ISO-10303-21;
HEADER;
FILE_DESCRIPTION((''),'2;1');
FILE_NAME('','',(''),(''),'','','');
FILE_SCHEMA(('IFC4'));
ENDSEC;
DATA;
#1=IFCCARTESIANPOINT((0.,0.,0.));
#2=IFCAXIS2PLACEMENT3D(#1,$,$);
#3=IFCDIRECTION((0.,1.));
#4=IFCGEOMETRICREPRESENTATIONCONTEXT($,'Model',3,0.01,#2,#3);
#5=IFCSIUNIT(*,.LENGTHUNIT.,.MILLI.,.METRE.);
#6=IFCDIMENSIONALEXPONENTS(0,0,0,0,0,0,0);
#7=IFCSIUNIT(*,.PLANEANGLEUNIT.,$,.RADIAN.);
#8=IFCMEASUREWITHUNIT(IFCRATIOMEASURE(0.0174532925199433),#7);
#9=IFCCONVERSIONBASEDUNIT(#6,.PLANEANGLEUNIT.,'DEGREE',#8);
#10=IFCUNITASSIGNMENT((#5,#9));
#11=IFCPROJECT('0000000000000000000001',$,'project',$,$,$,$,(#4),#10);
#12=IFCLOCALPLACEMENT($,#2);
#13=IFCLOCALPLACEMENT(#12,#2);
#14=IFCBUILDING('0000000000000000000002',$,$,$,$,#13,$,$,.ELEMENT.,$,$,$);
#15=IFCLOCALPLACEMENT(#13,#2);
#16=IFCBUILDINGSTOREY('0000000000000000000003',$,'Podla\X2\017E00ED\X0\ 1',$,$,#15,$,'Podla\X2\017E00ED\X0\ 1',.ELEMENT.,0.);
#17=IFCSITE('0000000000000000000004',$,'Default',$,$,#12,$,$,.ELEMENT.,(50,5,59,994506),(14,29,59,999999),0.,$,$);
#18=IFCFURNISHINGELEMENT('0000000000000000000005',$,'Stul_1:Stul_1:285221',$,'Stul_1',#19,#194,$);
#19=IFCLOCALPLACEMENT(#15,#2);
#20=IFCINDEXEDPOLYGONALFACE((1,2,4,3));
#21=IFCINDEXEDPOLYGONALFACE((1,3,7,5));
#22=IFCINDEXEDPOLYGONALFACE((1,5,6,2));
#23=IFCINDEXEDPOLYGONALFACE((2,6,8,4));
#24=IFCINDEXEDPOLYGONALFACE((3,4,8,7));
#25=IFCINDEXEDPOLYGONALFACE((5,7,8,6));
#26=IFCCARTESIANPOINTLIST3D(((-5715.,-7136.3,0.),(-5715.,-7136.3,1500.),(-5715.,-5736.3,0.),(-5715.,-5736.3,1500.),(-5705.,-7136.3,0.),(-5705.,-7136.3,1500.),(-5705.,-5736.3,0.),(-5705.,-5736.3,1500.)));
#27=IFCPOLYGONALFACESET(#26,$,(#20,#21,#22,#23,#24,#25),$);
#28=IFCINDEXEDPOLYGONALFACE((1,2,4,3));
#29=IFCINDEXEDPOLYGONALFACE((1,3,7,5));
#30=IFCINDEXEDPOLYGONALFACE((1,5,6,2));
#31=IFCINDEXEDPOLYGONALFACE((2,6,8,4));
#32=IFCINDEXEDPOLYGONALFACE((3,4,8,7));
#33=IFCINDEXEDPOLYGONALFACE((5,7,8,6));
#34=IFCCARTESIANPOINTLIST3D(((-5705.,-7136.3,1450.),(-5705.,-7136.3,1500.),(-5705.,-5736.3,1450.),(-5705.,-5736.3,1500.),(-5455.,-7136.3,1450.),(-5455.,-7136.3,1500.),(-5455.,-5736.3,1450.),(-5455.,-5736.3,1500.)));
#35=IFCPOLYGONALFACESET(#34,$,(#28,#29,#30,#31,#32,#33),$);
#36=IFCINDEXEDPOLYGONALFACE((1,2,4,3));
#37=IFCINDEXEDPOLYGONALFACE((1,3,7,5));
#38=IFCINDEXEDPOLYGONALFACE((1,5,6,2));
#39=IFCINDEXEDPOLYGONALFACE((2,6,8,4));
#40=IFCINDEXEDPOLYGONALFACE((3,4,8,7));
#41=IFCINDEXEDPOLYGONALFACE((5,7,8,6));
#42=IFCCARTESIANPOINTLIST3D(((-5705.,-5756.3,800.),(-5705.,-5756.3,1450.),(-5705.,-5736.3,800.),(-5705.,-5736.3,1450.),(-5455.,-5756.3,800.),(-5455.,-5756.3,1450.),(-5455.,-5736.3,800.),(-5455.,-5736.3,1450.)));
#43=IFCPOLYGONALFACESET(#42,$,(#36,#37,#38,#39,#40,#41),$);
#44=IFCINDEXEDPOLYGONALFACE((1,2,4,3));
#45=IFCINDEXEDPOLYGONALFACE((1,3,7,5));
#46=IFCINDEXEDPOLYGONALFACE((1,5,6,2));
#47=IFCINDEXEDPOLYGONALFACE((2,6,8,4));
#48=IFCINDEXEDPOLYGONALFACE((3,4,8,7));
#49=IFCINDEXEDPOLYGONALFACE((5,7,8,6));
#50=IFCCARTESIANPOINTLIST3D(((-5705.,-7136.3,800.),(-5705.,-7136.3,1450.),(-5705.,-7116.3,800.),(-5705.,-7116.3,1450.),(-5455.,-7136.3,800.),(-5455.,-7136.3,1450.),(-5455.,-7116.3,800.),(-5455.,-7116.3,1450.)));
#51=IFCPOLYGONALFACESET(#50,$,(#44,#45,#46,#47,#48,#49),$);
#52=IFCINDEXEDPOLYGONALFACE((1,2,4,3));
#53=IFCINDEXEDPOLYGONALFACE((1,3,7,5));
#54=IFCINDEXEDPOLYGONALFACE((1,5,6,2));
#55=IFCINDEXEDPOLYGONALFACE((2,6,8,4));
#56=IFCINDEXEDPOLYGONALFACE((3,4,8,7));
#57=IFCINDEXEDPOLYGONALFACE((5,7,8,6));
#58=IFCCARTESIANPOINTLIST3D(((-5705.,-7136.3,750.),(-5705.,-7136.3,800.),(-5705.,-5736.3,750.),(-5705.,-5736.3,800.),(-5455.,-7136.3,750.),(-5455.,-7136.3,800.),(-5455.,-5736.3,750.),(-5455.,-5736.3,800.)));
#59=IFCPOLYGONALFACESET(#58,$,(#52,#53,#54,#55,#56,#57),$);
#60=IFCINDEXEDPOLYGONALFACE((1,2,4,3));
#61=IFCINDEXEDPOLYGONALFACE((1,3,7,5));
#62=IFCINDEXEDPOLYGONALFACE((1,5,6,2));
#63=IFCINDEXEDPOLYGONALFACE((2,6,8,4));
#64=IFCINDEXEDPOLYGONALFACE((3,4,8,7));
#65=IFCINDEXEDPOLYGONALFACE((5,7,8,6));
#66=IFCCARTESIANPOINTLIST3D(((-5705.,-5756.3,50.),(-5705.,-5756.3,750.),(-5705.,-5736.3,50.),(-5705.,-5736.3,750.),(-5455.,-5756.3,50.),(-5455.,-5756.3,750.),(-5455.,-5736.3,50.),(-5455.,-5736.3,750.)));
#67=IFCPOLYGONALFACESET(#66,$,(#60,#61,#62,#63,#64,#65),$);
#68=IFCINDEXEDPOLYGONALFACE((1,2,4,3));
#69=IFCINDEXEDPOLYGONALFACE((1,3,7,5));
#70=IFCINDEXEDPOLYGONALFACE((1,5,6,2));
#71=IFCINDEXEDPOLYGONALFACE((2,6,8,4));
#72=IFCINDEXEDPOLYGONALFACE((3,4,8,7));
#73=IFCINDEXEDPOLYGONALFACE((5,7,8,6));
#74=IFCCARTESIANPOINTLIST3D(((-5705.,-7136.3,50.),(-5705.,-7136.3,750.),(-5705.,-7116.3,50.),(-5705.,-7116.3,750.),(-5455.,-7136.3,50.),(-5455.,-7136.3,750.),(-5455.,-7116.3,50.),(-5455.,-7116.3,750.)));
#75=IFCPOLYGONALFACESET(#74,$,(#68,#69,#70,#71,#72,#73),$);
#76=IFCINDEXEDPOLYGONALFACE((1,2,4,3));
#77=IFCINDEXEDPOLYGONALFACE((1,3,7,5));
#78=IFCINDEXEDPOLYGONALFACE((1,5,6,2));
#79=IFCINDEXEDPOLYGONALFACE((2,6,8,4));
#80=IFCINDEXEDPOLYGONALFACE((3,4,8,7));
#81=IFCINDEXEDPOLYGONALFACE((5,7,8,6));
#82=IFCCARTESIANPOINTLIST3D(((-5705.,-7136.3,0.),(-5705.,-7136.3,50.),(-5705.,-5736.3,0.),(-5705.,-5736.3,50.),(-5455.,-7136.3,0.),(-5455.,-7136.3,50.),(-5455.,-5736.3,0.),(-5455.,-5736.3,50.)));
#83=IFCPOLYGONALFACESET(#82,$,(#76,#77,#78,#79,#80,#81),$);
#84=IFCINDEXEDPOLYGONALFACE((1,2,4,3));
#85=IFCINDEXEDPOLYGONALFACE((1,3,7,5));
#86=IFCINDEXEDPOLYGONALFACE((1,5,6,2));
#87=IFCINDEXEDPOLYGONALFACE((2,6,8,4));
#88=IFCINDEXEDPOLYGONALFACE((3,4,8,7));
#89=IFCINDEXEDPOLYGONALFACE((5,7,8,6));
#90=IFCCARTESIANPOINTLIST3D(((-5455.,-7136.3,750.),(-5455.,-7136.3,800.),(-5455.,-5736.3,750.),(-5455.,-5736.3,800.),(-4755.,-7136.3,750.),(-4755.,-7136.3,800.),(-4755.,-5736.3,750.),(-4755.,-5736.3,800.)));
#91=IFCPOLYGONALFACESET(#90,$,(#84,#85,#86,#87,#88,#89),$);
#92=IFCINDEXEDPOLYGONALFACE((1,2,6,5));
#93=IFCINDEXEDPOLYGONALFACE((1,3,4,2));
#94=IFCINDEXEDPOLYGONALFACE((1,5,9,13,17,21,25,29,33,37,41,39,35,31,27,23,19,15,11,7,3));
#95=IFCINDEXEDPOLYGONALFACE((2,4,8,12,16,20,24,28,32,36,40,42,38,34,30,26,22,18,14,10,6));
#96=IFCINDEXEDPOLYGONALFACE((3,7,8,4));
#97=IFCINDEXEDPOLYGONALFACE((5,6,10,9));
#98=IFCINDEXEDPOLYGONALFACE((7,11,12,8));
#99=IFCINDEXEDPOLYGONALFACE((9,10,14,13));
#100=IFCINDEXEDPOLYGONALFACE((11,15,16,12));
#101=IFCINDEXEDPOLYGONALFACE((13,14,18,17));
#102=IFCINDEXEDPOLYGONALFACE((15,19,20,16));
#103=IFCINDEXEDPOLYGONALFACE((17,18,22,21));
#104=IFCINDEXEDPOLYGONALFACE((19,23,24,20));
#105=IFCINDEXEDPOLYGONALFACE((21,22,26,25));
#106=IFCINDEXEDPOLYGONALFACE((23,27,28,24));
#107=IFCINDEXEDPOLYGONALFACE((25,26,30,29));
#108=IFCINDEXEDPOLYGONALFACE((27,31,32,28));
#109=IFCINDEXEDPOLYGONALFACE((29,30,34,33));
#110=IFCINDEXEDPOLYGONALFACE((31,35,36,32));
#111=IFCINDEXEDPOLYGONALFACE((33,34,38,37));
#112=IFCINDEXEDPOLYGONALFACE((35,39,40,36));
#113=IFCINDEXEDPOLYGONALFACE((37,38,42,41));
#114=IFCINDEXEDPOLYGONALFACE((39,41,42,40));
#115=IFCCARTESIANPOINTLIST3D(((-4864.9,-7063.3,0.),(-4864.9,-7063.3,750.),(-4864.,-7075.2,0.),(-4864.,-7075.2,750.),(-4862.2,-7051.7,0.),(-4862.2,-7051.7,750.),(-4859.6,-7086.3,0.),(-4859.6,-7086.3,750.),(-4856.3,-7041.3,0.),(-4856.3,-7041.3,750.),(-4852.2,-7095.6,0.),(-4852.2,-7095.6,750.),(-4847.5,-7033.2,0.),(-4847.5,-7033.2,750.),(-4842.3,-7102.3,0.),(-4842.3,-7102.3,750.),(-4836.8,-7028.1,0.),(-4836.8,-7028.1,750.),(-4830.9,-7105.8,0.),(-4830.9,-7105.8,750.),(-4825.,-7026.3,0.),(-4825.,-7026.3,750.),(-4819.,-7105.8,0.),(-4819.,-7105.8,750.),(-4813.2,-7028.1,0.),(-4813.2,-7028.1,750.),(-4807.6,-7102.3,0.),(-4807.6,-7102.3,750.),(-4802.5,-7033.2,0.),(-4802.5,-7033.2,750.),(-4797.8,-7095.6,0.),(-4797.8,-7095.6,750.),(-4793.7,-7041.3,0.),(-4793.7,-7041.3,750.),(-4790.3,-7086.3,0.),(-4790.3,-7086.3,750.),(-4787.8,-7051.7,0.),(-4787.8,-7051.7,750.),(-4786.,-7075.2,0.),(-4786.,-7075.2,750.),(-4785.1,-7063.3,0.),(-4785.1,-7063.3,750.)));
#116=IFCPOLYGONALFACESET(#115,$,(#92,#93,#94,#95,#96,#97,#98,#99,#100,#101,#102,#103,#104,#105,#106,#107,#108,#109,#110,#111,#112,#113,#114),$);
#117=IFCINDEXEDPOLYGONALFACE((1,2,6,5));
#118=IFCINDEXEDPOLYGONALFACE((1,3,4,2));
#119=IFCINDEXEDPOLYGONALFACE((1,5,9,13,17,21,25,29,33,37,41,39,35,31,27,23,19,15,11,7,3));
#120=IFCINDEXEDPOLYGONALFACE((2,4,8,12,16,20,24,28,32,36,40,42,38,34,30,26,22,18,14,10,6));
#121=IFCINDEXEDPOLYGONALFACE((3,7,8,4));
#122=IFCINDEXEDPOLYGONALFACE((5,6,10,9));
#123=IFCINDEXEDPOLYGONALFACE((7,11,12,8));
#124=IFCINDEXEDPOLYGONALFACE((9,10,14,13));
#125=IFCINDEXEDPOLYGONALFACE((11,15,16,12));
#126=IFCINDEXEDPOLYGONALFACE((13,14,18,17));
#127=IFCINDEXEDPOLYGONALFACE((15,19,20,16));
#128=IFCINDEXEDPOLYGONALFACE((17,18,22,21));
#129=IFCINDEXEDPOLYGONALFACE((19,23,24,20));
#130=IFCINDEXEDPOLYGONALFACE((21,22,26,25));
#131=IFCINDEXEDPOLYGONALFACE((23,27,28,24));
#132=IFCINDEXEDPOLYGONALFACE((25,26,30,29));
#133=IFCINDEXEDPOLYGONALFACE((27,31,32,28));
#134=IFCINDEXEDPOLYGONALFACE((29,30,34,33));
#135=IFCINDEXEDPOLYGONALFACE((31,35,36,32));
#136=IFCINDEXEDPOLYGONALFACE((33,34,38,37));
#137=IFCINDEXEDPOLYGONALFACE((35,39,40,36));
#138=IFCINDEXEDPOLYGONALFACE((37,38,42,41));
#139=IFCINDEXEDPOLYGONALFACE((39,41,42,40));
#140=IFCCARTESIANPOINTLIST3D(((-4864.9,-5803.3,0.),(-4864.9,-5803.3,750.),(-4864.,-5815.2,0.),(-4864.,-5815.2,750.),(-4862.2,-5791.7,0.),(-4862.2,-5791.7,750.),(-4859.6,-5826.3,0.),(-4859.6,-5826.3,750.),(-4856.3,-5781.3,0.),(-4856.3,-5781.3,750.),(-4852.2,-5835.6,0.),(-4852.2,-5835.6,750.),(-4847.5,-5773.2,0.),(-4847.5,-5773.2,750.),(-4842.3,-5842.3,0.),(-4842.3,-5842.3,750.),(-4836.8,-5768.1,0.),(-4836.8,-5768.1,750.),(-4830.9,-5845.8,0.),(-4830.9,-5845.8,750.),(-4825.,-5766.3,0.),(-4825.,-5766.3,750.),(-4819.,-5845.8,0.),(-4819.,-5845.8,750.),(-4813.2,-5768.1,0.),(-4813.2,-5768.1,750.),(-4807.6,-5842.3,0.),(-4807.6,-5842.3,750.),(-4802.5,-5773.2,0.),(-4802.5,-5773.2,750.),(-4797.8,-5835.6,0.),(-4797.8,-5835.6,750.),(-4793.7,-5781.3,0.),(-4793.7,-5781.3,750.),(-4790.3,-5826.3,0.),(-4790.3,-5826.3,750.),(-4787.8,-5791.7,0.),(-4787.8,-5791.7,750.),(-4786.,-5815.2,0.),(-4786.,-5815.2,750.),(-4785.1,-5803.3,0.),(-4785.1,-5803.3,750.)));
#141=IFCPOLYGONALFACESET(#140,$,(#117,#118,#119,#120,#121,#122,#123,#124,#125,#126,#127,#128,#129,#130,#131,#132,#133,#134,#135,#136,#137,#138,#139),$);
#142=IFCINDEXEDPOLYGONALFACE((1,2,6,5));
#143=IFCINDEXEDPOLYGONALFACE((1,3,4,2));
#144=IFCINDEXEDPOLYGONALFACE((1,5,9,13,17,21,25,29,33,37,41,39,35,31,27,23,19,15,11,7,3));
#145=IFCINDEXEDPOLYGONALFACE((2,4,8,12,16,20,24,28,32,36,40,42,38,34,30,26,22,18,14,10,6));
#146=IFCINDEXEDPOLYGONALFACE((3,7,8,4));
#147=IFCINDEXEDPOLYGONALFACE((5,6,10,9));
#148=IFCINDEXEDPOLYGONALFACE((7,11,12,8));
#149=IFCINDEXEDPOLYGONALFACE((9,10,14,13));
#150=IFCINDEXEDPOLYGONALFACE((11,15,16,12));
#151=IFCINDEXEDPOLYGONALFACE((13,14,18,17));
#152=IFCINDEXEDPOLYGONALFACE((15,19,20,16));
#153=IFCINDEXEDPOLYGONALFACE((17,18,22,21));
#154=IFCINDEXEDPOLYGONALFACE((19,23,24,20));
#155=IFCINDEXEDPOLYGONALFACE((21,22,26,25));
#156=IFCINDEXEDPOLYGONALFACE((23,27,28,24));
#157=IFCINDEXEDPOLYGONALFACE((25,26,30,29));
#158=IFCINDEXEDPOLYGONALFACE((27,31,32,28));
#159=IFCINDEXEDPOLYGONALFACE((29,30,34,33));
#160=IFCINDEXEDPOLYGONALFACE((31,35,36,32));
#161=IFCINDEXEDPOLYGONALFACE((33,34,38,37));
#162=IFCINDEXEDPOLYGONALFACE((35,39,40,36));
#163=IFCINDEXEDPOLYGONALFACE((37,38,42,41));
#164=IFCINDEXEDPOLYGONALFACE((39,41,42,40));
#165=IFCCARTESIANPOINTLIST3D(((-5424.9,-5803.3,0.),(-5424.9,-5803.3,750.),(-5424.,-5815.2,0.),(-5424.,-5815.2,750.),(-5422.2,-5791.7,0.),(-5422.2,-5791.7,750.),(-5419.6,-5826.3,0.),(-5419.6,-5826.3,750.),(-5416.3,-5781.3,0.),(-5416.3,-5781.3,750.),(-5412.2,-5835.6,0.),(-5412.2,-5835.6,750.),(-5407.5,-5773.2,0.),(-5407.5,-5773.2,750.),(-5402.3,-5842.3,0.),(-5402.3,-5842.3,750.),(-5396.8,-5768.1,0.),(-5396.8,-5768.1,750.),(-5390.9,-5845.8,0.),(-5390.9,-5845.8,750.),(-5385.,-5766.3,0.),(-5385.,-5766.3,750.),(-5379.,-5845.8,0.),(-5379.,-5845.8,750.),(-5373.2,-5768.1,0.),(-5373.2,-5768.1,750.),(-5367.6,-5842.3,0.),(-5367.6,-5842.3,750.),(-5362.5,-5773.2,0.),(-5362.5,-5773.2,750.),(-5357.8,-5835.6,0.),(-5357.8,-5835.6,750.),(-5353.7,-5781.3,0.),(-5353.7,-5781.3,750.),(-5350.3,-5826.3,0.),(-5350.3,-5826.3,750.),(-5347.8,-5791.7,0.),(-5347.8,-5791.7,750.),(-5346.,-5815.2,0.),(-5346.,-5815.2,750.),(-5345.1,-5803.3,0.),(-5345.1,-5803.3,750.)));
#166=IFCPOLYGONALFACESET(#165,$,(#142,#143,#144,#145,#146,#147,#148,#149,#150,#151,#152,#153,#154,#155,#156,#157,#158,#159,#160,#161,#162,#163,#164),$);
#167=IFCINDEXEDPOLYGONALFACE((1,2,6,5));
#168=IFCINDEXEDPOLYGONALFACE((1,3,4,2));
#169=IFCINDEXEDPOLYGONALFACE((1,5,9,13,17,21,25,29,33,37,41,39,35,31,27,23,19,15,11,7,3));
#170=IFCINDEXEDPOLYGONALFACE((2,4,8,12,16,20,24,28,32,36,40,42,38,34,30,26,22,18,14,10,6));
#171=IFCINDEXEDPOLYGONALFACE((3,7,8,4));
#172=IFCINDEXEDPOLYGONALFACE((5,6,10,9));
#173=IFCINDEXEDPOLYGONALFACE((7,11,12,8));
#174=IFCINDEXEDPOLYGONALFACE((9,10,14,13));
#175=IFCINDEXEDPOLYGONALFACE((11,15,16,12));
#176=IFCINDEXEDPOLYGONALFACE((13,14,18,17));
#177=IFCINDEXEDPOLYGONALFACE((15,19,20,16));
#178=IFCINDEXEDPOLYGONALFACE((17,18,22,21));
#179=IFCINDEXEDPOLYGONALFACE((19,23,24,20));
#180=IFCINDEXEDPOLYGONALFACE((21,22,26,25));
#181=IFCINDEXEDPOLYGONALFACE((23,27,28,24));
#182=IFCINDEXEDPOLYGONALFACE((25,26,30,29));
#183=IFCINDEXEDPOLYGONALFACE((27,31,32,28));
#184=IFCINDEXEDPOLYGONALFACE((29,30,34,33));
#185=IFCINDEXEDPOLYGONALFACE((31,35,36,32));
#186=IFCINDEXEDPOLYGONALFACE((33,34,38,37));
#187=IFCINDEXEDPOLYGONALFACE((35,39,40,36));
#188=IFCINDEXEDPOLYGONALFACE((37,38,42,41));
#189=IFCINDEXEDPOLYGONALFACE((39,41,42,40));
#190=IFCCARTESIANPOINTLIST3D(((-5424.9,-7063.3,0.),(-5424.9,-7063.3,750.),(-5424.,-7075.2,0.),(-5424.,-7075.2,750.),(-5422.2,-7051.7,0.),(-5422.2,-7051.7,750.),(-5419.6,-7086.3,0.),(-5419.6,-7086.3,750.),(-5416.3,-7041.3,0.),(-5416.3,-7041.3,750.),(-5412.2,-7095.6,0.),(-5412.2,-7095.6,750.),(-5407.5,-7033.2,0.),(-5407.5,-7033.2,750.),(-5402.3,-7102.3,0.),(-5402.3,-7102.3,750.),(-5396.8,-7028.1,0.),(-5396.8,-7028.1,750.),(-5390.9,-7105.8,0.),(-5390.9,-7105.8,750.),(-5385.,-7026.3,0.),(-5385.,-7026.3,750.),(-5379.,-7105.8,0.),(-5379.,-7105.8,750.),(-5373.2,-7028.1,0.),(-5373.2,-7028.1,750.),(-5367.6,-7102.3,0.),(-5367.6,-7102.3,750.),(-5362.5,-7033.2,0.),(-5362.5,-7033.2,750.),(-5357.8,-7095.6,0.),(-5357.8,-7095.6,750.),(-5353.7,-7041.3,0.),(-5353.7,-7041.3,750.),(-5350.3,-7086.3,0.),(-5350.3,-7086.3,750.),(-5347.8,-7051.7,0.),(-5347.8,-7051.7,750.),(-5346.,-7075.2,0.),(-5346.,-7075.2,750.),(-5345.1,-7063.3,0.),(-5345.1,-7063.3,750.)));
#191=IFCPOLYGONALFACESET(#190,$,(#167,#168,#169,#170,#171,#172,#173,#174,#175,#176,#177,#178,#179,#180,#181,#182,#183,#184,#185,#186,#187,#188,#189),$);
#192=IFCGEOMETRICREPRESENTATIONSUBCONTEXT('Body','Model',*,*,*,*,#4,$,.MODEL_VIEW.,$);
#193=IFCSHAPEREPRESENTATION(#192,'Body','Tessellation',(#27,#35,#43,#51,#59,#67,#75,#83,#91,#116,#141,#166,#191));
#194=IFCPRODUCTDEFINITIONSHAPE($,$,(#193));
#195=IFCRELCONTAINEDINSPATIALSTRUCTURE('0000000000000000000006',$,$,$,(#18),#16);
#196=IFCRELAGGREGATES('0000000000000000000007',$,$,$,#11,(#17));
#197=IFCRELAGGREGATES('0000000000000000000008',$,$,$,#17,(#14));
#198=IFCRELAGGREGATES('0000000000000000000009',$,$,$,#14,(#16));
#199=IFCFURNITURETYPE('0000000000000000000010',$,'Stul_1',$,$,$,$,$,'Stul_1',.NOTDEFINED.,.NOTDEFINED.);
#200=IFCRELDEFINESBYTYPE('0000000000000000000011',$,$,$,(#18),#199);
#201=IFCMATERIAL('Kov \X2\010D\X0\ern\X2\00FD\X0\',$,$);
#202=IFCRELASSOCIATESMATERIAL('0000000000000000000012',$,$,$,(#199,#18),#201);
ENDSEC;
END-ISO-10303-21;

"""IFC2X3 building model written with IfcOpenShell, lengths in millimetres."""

from ifc_helpers import new_model, entity, si_unit, converted_unit, direction, frame, frame_2d, origin, origin_2d_with_axis, place, context, subcontext, project, spatial, rectangle, circle, extrude, source, transform, mapped, material, type_object, type_shapes, element, save


model = new_model("IFC2X3")

# Units and contexts
model_context = context("Model", 3, precision=0.01, world=origin(), true_north=direction((0.0, 1.0)))
body_context = subcontext(model_context, "Body", "Model", "MODEL_VIEW")
ifc_project = project(units=[si_unit("LENGTHUNIT", "METRE", prefix="MILLI"), converted_unit("PLANEANGLEUNIT", "DEGREE", entity("IfcRatioMeasure", 0.0174532925199433), si_unit("PLANEANGLEUNIT", "RADIAN"), dimensions=[0, 0, 0, 0, 0, 0, 0])], contexts=[model_context])

# Site, building, storey
site_placement = place(None, origin())
site = spatial("IfcSite", under=ifc_project, at=site_placement, Name="Default", CompositionType="ELEMENT", RefLatitude=(50, 5, 59, 994506), RefLongitude=(14, 29, 59, 999999), RefElevation=0.0)
building_placement = place(site_placement, origin())
building = spatial("IfcBuilding", under=site, at=building_placement, CompositionType="ELEMENT")
storey_placement = place(building_placement, origin())
storey = spatial("IfcBuildingStorey", under=building, at=storey_placement, Name="Podlaží 1", LongName="Podlaží 1", CompositionType="ELEMENT", Elevation=0.0)

# Furnishing element
ifc_material_1 = material(Name="Kov černý")
furniture_type = type_object("IfcFurnitureType", Name="Stul_1", ElementType="Stul_1", material=ifc_material_1)
shared_shape_1 = source(origin(), body_context, "Body", "SweptSolid", [
    extrude(rectangle(XDim=1400.0, YDim=10.0, at=origin_2d_with_axis()), frame((0.0, 605.0, 0.0), z_axis=(0.0, 0.0, 1.0), x_axis=(-1.0, 0.0, 0.0)), (0.0, 0.0, 1.0), 1500.0),
    extrude(rectangle(XDim=1400.0, YDim=250.0, at=frame_2d((0.0, 0.0), x_axis=(1.0, 0.0))), frame((0.0, 475.0, 1450.0), z_axis=(0.0, 0.0, 1.0), x_axis=(-1.0, 0.0, 0.0)), (0.0, 0.0, 1.0), 50.0),
    extrude(rectangle(XDim=20.0, YDim=250.0, at=origin_2d_with_axis()), frame((690.0, 475.0, 800.0), z_axis=(0.0, 0.0, 1.0), x_axis=(-1.0, 0.0, 0.0)), (0.0, 0.0, 1.0), 650.0),
    extrude(rectangle(XDim=20.0, YDim=250.0, at=frame_2d((0.0, 0.0), x_axis=(1.0, 0.0))), frame((-690.0, 475.0, 800.0), z_axis=(0.0, 0.0, 1.0), x_axis=(-1.0, 0.0, 0.0)), (0.0, 0.0, 1.0), 650.0),
    extrude(rectangle(XDim=1400.0, YDim=250.0, at=origin_2d_with_axis()), frame((0.0, 475.0, 750.0), z_axis=(0.0, 0.0, 1.0), x_axis=(-1.0, 0.0, 0.0)), (0.0, 0.0, 1.0), 50.0),
    extrude(rectangle(XDim=20.0, YDim=250.0, at=origin_2d_with_axis()), frame((690.0, 475.0, 50.0), z_axis=(0.0, 0.0, 1.0), x_axis=(-1.0, 0.0, 0.0)), (0.0, 0.0, 1.0), 700.0),
    extrude(rectangle(XDim=20.0, YDim=250.0, at=frame_2d((0.0, 0.0), x_axis=(1.0, 0.0))), frame((-690.0, 475.0, 50.0), z_axis=(0.0, 0.0, 1.0), x_axis=(-1.0, 0.0, 0.0)), (0.0, 0.0, 1.0), 700.0),
    extrude(rectangle(XDim=1400.0, YDim=250.0, at=origin_2d_with_axis()), frame((0.0, 475.0, 0.0), z_axis=(0.0, 0.0, 1.0), x_axis=(-1.0, 0.0, 0.0)), (0.0, 0.0, 1.0), 50.0),
    extrude(rectangle(XDim=1400.0, YDim=700.0, at=origin_2d_with_axis()), frame((0.0, 0.0, 750.0), z_axis=(0.0, 0.0, 1.0), x_axis=(-1.0, 0.0, 0.0)), (0.0, 0.0, 1.0), 50.0),
    extrude(circle(Radius=40.0, at=frame_2d((0.0, 0.0), x_axis=(1.0, 0.0))), frame((-630.0, -280.0, 0.0)), (0.0, 0.0, 1.0), 750.0),
    extrude(circle(Radius=40.0, at=frame_2d((0.0, 0.0), x_axis=(1.0, 0.0))), frame((630.0, -280.0, 0.0)), (0.0, 0.0, 1.0), 750.0),
    extrude(circle(Radius=40.0, at=frame_2d((0.0, 0.0), x_axis=(1.0, 0.0))), frame((630.0, 280.0, 0.0)), (0.0, 0.0, 1.0), 750.0),
    extrude(circle(Radius=40.0, at=frame_2d((0.0, 0.0), x_axis=(1.0, 0.0))), frame((-630.0, 280.0, 0.0)), (0.0, 0.0, 1.0), 750.0),
])
type_shapes(furniture_type, [shared_shape_1])
for number, where, z_axis, x_axis, name in (
    (1, (-5105.0, -6436.3, 0.0), (0.0, 0.0, 1.0), (0.0, 1.0, 0.0), "Stul_1:Stul_1:285221"),
):
    element("IfcFurnishingElement", number, at=place(storey_placement, frame(where, z_axis=z_axis, x_axis=x_axis)), inside=storey, type_object=furniture_type, material=ifc_material_1, Name=name, ObjectType="Stul_1", context=body_context, shape_type="MappedRepresentation", body=[
        mapped(shared_shape_1, transform((0.0, 0.0, 0.0), scale=1.0)),
    ])

save(model, "model.ifc")
